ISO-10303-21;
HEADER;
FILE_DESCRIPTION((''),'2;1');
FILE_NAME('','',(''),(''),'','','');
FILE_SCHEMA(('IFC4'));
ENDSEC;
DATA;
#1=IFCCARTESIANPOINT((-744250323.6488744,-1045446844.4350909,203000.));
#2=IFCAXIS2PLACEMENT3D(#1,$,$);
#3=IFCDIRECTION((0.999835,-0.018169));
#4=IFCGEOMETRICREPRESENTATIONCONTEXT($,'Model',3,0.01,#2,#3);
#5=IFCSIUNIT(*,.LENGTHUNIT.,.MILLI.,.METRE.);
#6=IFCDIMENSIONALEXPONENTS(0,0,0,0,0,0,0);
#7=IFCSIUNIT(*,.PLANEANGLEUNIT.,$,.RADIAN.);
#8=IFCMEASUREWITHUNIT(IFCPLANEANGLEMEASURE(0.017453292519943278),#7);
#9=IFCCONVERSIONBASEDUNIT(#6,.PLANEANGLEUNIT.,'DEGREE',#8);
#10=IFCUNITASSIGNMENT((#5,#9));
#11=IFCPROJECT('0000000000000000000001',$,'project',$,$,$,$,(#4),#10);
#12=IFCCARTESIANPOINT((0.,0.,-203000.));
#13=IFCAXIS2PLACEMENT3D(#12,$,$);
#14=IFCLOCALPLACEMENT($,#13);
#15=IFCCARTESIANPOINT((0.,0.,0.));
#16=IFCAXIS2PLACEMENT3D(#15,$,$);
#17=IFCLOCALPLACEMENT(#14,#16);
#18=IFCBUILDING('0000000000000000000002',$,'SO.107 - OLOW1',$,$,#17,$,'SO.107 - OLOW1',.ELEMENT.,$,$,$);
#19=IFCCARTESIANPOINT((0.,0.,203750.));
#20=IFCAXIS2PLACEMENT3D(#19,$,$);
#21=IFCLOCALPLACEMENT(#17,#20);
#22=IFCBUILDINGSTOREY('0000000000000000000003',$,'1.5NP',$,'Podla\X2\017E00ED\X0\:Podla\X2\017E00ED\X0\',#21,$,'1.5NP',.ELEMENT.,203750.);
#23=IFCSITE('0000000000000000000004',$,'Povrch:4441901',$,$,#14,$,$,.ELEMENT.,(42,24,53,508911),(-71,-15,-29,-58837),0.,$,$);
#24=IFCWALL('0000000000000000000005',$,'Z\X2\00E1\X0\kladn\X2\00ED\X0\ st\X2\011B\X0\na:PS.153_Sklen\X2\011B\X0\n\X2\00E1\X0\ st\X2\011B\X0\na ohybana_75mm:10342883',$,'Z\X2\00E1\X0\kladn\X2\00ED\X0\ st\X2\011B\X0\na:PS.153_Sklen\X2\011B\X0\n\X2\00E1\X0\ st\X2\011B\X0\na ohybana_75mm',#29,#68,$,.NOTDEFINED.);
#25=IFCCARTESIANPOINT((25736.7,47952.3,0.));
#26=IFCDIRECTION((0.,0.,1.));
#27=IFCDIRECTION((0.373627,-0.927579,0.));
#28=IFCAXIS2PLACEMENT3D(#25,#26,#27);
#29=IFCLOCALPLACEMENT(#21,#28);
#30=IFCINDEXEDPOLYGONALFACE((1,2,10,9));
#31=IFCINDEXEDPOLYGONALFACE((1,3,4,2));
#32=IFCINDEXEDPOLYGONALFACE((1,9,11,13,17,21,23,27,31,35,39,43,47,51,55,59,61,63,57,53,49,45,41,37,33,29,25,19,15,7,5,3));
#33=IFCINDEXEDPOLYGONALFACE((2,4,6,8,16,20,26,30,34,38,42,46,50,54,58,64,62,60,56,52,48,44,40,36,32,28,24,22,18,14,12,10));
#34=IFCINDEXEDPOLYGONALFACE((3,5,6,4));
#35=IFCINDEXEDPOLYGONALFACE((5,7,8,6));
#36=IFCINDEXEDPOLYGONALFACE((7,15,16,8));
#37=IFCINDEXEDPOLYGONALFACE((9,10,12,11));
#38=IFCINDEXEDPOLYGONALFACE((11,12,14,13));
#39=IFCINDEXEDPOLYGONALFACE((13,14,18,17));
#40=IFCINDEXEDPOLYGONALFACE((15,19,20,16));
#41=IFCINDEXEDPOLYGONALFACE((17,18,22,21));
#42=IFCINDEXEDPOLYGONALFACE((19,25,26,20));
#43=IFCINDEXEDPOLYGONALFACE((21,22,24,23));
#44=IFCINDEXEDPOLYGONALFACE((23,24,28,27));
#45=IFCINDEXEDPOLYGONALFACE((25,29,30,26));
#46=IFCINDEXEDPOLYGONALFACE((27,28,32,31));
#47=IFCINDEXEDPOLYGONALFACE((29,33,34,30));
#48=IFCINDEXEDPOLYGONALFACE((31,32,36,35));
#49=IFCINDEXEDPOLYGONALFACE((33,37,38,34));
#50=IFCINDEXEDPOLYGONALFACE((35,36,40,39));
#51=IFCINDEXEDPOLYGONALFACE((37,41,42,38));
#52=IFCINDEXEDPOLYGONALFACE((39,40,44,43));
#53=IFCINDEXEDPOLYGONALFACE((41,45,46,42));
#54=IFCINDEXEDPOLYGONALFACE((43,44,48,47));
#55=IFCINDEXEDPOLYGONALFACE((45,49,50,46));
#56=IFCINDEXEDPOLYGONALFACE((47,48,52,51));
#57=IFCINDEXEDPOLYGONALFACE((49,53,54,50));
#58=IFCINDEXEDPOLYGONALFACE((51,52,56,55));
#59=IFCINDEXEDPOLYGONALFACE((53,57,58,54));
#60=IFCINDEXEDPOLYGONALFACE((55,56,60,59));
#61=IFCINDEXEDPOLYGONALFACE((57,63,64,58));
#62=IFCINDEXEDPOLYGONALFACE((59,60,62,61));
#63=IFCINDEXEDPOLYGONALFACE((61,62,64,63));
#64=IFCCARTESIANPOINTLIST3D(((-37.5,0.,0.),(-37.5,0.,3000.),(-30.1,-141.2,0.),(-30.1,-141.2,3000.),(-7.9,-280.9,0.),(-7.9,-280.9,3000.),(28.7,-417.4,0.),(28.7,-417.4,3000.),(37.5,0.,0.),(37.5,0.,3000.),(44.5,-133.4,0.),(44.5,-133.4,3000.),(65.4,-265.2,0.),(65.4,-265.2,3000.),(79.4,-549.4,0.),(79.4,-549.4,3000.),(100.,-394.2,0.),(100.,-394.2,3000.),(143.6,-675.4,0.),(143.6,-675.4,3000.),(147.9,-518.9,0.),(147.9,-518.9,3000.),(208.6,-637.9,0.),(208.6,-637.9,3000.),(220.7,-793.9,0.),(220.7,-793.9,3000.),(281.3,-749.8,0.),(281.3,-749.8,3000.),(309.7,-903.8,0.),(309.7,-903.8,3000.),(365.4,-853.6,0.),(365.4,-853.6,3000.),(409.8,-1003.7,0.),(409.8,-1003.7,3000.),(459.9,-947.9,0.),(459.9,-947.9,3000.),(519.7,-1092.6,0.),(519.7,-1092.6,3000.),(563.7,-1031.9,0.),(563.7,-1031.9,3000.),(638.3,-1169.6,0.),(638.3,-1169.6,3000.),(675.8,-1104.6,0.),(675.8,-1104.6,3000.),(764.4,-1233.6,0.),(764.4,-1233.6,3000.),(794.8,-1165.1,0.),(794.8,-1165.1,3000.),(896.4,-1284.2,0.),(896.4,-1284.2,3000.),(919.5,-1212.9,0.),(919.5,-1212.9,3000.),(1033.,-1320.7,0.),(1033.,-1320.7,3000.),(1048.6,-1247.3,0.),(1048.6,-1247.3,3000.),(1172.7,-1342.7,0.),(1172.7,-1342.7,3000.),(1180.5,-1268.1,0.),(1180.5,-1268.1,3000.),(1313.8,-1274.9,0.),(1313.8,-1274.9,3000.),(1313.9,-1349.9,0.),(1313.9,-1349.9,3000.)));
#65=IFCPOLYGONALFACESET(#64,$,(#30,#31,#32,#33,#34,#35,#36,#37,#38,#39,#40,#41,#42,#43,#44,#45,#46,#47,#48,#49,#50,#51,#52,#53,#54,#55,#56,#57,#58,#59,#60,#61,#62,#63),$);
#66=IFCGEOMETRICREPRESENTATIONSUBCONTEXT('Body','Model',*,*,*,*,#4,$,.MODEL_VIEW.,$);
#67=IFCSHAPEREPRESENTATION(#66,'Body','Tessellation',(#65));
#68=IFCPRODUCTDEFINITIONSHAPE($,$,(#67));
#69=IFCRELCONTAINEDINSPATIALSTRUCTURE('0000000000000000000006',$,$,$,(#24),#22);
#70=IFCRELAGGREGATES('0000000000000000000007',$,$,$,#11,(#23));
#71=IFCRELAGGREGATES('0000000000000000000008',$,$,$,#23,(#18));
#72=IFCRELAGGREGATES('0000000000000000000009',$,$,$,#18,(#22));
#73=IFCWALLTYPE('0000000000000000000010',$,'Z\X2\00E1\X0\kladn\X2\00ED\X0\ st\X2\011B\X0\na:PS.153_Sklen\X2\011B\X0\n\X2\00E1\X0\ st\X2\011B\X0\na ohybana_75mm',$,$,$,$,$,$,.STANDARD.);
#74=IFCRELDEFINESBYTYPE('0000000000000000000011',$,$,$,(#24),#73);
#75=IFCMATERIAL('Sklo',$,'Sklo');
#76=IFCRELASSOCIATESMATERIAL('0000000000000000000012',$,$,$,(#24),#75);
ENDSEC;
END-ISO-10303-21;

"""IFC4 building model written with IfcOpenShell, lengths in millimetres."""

from ifc_helpers import new_model, entity, si_unit, converted_unit, direction, frame, origin, place, context, subcontext, project, spatial, line, arc, indexed_curve, outline, extrude, material, type_object, element, save


model = new_model("IFC4")

# Units and contexts
model_context = context("Model", 3, precision=0.01, world=frame((-744250323.6488744, -1045446844.4350909, 203000.0)), true_north=direction((0.999835, -0.018169)))
body_context = subcontext(model_context, "Body", "Model", "MODEL_VIEW")
ifc_project = project(units=[si_unit("LENGTHUNIT", "METRE", prefix="MILLI"), converted_unit("PLANEANGLEUNIT", "DEGREE", entity("IfcPlaneAngleMeasure", 0.017453292519943278), si_unit("PLANEANGLEUNIT", "RADIAN"), dimensions=[0, 0, 0, 0, 0, 0, 0])], contexts=[model_context])

# Site, building, storey
site_placement = place(None, frame((0.0, 0.0, -203000.0)))
site = spatial("IfcSite", under=ifc_project, at=site_placement, Name="Povrch:4441901", CompositionType="ELEMENT", RefLatitude=(42, 24, 53, 508911), RefLongitude=(-71, -15, -29, -58837), RefElevation=0.0)
building_placement = place(site_placement, origin())
building = spatial("IfcBuilding", under=site, at=building_placement, Name="SO.107 - OLOW1", LongName="SO.107 - OLOW1", CompositionType="ELEMENT")
storey_placement = place(building_placement, frame((0.0, 0.0, 203750.0)))
storey = spatial("IfcBuildingStorey", under=building, at=storey_placement, Name="1.5NP", ObjectType="Podlaží:Podlaží", LongName="1.5NP", CompositionType="ELEMENT", Elevation=203750.0)

# Shared definitions
ifc_material_1 = material(Name="Sklo", Category="Sklo")

# Wall
wall_type = type_object("IfcWallType", Name="Základní stěna:PS.153_Skleněná stěna ohybana_75mm", PredefinedType="STANDARD")
wall_placement = place(storey_placement, frame((25736.7, 47952.3, 0.0), z_axis=(0.0, 0.0, 1.0), x_axis=(0.373627, -0.927579, 0.0)))
element("IfcWall", 1, at=wall_placement, inside=storey, type_object=wall_type, material=ifc_material_1, Name="Základní stěna:PS.153_Skleněná stěna ohybana_75mm:10342883", ObjectType="Základní stěna:PS.153_Skleněná stěna ohybana_75mm", PredefinedType="NOTDEFINED", context=body_context, shape_type="SweptSolid", body=[
    extrude(outline(indexed_curve([(1313.8, -1274.9), (411.4, -902.0), (37.5, 0.0), (-37.5, 0.0), (358.4, -955.1), (1313.9, -1349.9)], segments=[arc(1, 2, 3), line(3, 4), arc(4, 5, 6), line(6, 1)], self_intersect=False)), origin(), (0.0, 0.0, 1.0), 3000.0),
])

save(model, "model.ifc")
